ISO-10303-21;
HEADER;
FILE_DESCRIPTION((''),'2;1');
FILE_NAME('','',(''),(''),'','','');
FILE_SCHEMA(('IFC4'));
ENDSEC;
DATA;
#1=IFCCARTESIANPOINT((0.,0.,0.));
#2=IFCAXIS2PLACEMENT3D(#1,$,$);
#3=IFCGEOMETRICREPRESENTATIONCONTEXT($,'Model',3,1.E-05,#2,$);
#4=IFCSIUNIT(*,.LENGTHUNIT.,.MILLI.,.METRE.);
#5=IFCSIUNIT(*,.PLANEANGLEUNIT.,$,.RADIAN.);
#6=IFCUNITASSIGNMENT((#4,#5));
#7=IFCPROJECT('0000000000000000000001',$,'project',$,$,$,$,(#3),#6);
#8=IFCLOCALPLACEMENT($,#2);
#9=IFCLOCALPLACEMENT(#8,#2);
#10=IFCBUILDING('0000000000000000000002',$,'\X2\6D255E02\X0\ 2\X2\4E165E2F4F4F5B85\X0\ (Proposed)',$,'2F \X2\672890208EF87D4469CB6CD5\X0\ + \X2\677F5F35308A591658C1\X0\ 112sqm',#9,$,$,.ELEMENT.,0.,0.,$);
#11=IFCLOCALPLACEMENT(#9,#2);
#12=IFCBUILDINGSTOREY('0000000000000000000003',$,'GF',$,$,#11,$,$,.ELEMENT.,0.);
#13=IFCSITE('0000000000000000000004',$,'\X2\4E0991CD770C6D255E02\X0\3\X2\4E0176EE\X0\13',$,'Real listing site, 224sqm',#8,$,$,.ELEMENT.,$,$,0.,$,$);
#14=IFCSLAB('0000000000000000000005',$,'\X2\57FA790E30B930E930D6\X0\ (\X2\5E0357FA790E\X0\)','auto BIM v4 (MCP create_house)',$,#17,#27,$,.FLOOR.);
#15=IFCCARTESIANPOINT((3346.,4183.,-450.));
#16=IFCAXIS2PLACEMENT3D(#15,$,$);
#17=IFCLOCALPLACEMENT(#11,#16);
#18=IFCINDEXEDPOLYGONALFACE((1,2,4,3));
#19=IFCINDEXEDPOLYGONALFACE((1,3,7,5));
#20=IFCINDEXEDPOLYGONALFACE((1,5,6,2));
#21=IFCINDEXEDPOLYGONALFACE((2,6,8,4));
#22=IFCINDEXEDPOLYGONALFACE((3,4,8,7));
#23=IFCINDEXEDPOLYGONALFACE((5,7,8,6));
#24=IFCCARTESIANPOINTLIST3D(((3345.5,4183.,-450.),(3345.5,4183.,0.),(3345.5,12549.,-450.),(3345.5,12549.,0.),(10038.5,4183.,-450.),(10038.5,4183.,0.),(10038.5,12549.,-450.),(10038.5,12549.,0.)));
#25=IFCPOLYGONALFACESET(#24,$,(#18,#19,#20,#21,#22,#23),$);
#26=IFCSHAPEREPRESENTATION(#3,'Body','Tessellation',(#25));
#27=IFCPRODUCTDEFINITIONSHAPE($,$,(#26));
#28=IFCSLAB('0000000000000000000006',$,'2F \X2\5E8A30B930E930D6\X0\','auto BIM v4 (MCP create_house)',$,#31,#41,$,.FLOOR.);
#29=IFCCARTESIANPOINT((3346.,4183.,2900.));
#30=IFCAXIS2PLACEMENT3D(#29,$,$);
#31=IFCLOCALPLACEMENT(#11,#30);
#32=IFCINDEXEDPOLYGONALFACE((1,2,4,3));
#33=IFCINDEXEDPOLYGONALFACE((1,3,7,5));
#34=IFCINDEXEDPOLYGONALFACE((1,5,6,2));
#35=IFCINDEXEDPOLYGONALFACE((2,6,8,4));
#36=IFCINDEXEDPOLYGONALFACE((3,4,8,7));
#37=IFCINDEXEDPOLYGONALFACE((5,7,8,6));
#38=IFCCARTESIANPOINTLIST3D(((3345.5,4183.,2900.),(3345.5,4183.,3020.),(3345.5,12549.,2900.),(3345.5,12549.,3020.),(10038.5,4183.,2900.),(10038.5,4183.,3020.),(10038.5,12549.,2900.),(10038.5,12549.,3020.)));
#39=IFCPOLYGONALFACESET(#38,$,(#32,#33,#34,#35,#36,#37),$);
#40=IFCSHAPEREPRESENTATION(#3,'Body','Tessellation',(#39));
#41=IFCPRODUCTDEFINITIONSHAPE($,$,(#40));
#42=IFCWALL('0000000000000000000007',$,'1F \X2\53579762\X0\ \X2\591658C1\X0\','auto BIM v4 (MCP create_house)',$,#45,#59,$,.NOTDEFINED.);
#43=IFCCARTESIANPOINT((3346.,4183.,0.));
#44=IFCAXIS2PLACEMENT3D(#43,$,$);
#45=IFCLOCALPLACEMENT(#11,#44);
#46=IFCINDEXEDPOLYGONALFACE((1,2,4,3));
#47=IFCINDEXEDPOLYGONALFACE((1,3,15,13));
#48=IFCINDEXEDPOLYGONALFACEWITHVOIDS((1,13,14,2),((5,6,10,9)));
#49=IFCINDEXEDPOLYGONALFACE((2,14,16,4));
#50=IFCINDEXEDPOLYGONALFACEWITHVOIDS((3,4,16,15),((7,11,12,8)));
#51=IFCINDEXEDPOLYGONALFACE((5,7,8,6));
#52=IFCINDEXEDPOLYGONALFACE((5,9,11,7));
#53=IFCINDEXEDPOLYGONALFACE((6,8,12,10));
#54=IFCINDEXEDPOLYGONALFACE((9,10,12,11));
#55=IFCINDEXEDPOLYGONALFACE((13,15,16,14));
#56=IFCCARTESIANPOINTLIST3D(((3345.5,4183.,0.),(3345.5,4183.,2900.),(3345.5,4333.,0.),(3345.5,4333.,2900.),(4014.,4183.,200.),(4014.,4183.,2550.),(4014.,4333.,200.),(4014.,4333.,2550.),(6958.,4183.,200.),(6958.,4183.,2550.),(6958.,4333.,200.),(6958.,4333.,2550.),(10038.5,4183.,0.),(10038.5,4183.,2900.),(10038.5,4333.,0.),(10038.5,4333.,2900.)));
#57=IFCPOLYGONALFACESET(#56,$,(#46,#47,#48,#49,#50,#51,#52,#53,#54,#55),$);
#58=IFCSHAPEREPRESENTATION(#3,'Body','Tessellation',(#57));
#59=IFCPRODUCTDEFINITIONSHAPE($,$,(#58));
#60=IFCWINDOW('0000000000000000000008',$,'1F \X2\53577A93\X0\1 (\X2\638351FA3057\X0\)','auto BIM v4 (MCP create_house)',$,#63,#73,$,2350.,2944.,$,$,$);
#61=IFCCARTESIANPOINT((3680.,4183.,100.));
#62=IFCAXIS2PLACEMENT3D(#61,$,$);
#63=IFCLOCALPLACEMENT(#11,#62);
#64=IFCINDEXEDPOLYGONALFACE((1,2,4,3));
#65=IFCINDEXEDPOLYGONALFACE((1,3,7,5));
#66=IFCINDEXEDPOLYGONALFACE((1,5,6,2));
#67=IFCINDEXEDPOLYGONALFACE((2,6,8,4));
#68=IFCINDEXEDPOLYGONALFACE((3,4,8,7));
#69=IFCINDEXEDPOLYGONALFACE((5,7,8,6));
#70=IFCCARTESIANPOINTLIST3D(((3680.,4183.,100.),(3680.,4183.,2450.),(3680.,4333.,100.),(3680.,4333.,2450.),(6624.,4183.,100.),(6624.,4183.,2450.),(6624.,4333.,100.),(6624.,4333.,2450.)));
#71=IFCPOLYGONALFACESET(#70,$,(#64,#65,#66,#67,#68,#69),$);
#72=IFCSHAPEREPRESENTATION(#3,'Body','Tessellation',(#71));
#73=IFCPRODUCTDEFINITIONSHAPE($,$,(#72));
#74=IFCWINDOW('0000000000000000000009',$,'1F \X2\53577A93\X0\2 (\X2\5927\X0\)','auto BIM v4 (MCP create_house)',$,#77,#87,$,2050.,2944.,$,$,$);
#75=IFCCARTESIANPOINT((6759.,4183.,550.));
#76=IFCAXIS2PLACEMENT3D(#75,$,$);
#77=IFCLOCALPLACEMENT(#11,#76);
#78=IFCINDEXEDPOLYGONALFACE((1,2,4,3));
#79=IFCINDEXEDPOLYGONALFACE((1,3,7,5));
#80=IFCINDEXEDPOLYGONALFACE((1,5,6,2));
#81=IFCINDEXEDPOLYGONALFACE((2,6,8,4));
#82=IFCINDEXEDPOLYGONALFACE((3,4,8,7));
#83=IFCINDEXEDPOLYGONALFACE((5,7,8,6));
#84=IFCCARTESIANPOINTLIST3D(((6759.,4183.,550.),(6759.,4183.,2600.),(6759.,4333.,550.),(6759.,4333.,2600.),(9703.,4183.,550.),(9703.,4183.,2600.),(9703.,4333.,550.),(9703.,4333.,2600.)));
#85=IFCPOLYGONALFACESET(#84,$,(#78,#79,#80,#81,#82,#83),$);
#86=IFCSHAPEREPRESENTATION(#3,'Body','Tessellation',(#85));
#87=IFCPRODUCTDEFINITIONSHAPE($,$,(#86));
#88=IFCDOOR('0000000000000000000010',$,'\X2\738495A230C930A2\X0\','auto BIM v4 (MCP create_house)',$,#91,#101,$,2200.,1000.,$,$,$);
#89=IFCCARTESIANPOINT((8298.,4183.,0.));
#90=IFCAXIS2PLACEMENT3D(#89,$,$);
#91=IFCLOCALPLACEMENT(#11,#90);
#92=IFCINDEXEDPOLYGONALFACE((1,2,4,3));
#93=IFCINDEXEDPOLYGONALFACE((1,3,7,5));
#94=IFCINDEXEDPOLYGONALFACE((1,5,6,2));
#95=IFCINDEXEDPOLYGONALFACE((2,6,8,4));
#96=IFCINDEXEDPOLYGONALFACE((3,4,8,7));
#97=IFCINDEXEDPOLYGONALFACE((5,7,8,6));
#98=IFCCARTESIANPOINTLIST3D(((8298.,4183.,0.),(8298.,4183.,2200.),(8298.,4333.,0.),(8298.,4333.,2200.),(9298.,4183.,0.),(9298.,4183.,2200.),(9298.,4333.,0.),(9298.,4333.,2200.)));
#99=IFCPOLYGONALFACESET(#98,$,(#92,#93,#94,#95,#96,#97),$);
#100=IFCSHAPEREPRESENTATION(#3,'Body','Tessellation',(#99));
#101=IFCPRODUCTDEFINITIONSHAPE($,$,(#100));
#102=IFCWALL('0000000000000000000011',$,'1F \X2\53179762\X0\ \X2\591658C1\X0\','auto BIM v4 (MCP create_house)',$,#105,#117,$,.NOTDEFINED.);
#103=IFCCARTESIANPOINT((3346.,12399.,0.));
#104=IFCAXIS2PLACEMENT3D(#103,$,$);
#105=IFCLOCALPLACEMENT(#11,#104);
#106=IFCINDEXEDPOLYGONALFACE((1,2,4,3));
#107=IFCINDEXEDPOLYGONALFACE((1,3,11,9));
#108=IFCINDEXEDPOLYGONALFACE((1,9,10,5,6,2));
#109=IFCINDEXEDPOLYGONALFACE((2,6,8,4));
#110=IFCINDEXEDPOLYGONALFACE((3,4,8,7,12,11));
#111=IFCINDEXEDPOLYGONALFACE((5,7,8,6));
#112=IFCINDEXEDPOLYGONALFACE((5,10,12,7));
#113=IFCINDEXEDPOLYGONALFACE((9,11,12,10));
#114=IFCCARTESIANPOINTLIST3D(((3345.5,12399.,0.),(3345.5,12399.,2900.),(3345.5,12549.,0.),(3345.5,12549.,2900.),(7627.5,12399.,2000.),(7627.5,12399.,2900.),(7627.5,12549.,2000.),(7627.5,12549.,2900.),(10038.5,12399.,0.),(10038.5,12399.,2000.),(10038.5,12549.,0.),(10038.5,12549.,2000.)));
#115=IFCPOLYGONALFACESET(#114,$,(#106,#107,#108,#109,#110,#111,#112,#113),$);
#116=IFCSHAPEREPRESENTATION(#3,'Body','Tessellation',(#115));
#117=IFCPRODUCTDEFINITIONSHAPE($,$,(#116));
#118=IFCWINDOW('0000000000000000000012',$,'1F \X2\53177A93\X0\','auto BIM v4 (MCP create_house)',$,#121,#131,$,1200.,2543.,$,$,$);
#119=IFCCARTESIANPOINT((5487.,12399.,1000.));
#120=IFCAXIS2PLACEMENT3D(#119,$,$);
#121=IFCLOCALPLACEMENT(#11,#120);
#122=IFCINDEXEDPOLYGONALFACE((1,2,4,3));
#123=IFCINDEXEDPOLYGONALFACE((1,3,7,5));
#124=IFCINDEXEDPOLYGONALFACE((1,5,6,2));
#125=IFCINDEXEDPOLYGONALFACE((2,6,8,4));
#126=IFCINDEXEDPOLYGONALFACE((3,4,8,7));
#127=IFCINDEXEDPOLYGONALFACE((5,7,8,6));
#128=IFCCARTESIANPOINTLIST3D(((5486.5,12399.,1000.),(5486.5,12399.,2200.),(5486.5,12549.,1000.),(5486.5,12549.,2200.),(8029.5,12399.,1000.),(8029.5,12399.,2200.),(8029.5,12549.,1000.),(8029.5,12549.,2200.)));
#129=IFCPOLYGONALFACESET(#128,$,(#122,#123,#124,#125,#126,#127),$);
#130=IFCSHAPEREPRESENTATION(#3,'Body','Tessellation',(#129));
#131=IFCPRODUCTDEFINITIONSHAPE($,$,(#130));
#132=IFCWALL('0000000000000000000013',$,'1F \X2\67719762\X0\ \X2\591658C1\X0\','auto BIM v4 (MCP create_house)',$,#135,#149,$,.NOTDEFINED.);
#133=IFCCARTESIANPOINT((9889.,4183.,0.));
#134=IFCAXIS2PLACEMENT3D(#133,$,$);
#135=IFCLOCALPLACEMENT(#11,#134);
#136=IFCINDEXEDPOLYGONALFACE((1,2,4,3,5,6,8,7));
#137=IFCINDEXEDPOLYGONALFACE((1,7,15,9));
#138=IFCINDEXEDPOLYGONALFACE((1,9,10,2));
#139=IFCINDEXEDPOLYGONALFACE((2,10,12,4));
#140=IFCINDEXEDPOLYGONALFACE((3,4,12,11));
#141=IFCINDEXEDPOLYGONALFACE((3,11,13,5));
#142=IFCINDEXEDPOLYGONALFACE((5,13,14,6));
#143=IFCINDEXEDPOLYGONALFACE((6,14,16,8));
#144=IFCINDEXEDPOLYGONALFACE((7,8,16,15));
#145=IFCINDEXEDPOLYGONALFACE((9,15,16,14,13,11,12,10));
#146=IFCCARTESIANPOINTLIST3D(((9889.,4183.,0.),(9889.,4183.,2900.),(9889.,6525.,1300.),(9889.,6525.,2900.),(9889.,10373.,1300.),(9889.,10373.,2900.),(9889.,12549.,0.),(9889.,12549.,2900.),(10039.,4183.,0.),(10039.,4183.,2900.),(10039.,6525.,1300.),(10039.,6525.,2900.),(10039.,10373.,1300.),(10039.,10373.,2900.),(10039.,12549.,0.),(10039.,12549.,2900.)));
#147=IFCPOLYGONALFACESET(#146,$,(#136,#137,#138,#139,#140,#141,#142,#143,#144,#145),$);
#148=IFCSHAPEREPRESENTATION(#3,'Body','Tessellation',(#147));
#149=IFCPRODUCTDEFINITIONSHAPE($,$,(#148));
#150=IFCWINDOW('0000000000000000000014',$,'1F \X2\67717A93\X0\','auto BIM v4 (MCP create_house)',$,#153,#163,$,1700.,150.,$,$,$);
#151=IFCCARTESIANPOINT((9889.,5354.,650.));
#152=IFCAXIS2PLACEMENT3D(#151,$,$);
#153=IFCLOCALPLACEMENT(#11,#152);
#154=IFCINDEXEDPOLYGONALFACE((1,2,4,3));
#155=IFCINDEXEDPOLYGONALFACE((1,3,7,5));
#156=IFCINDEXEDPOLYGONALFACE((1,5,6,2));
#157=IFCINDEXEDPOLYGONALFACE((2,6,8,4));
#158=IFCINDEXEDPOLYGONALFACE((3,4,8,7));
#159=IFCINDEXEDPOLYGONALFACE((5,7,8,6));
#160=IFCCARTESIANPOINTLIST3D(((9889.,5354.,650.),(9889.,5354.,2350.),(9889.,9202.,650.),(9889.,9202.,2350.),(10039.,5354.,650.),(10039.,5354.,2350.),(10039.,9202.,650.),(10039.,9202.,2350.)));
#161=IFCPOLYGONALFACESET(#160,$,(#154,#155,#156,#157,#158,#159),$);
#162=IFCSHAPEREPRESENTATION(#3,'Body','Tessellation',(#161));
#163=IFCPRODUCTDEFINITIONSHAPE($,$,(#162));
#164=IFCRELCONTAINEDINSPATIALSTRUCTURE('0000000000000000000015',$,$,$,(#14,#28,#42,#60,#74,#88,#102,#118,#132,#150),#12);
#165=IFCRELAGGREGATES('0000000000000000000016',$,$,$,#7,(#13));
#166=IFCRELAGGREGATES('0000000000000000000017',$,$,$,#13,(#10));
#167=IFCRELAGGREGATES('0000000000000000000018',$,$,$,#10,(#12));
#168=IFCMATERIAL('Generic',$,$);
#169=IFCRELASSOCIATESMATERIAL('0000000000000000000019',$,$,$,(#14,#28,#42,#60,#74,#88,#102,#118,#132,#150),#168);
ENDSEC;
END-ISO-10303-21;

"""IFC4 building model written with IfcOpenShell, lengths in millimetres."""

from ifc_helpers import new_model, si_unit, frame, frame_2d, origin, place, context, project, spatial, rectangle, extrude, material, element, fill, save


model = new_model("IFC4")

# Units and contexts
model_context = context("Model", 3, precision=1e-05, world=origin())
ifc_project = project(units=[si_unit("LENGTHUNIT", "METRE", prefix="MILLI"), si_unit("PLANEANGLEUNIT", "RADIAN")], contexts=[model_context])

# Site, building, storey
site_placement = place(None, origin())
site = spatial("IfcSite", under=ifc_project, at=site_placement, Name="三重県津市3丁目13", ObjectType="Real listing site, 224sqm", CompositionType="ELEMENT", RefElevation=0.0)
building_placement = place(site_placement, origin())
building = spatial("IfcBuilding", under=site, at=building_placement, Name="津市 2世帯住宅 (Proposed)", ObjectType="2F 木造軸組構法 + 板張り外壁 112sqm", CompositionType="ELEMENT", ElevationOfRefHeight=0.0, ElevationOfTerrain=0.0)
storey_placement = place(building_placement, origin())
storey = spatial("IfcBuildingStorey", under=building, at=storey_placement, Name="GF", CompositionType="ELEMENT", Elevation=0.0)

# Slabs
ifc_material = material(Name="Generic")
slab_1_placement = place(storey_placement, frame((3346.0, 4183.0, -450.0)))
element("IfcSlab", 1, at=slab_1_placement, inside=storey, material=ifc_material, Name="基礎スラブ (布基礎)", Description="auto BIM v4 (MCP create_house)", PredefinedType="FLOOR", context=model_context, shape_type="SweptSolid", body=[
    extrude(rectangle(XDim=6693.0, YDim=8366.0, at=frame_2d((3346.0, 4183.0))), frame((3346.0, 4183.0, -450.0)), (0.0, 0.0, 1.0), 450.0),
])
slab_2_placement = place(storey_placement, frame((3346.0, 4183.0, 2900.0)))
element("IfcSlab", 2, at=slab_2_placement, inside=storey, material=ifc_material, Name="2F 床スラブ", Description="auto BIM v4 (MCP create_house)", PredefinedType="FLOOR", context=model_context, shape_type="SweptSolid", body=[
    extrude(rectangle(XDim=6693.0, YDim=8366.0, at=frame_2d((3346.0, 4183.0))), frame((3346.0, 4183.0, 2900.0)), (0.0, 0.0, 1.0), 120.0),
])

# Wall, openings, windows, door
wall_1_placement = place(storey_placement, frame((3346.0, 4183.0, 0.0)))
wall_1 = element("IfcWall", 3, at=wall_1_placement, inside=storey, material=ifc_material, Name="1F 南面 外壁", Description="auto BIM v4 (MCP create_house)", PredefinedType="NOTDEFINED", context=model_context, shape_type="SweptSolid", body=[
    extrude(rectangle(XDim=6693.0, YDim=150.0, at=frame_2d((3346.0, 75.0))), frame((3346.0, 4183.0, 0.0)), (0.0, 0.0, 1.0), 2900.0),
])
opening_1_placement = place(storey_placement, frame((3680.0, 4183.0, 100.0)))
opening_1 = element("IfcOpeningElement", 4, at=opening_1_placement, cuts=wall_1, PredefinedType="NOTDEFINED", context=model_context, shape_type="SweptSolid", body=[
    extrude(rectangle(XDim=2944.0, YDim=150.0, at=frame_2d((1472.0, 75.0))), frame((3680.0, 4183.0, 100.0)), (0.0, 0.0, 1.0), 2350.0),
])
opening_2_placement = place(storey_placement, frame((6759.0, 4183.0, 550.0)))
opening_2 = element("IfcOpeningElement", 5, at=opening_2_placement, cuts=wall_1, PredefinedType="NOTDEFINED", context=model_context, shape_type="SweptSolid", body=[
    extrude(rectangle(XDim=2944.0, YDim=150.0, at=frame_2d((1472.0, 75.0))), frame((6759.0, 4183.0, 550.0)), (0.0, 0.0, 1.0), 2050.0),
])
opening_3_placement = place(storey_placement, frame((8298.0, 4183.0, 0.0)))
opening_3 = element("IfcOpeningElement", 6, at=opening_3_placement, cuts=wall_1, PredefinedType="NOTDEFINED", context=model_context, shape_type="SweptSolid", body=[
    extrude(rectangle(XDim=1000.0, YDim=150.0, at=frame_2d((500.0, 75.0))), frame((8298.0, 4183.0, 0.0)), (0.0, 0.0, 1.0), 2200.0),
])
window_1_placement = place(storey_placement, frame((3680.0, 4183.0, 100.0)))
window_1 = element("IfcWindow", 7, at=window_1_placement, inside=storey, material=ifc_material, Name="1F 南窓1 (掃出し)", Description="auto BIM v4 (MCP create_house)", OverallHeight=2350.0, OverallWidth=2944.0, context=model_context, shape_type="SweptSolid", body=[
    extrude(rectangle(XDim=2944.0, YDim=150.0, at=frame_2d((1472.0, 75.0))), frame((3680.0, 4183.0, 100.0)), (0.0, 0.0, 1.0), 2350.0),
])
fill(opening_1, window_1)
window_2_placement = place(storey_placement, frame((6759.0, 4183.0, 550.0)))
window_2 = element("IfcWindow", 8, at=window_2_placement, inside=storey, material=ifc_material, Name="1F 南窓2 (大)", Description="auto BIM v4 (MCP create_house)", OverallHeight=2050.0, OverallWidth=2944.0, context=model_context, shape_type="SweptSolid", body=[
    extrude(rectangle(XDim=2944.0, YDim=150.0, at=frame_2d((1472.0, 75.0))), frame((6759.0, 4183.0, 550.0)), (0.0, 0.0, 1.0), 2050.0),
])
fill(opening_2, window_2)
door_1_placement = place(storey_placement, frame((8298.0, 4183.0, 0.0)))
door_1 = element("IfcDoor", 9, at=door_1_placement, inside=storey, material=ifc_material, Name="玄関ドア", Description="auto BIM v4 (MCP create_house)", OverallHeight=2200.0, OverallWidth=1000.0, context=model_context, shape_type="SweptSolid", body=[
    extrude(rectangle(XDim=1000.0, YDim=150.0, at=frame_2d((500.0, 75.0))), frame((8298.0, 4183.0, 0.0)), (0.0, 0.0, 1.0), 2200.0),
])
fill(opening_3, door_1)

# Walls, openings, windows
wall_2_placement = place(storey_placement, frame((3346.0, 12399.0, 0.0)))
wall_2 = element("IfcWall", 10, at=wall_2_placement, inside=storey, material=ifc_material, Name="1F 北面 外壁", Description="auto BIM v4 (MCP create_house)", PredefinedType="NOTDEFINED", context=model_context, shape_type="SweptSolid", body=[
    extrude(rectangle(XDim=6693.0, YDim=150.0, at=frame_2d((3346.0, 75.0))), frame((3346.0, 12399.0, 0.0)), (0.0, 0.0, 1.0), 2900.0),
])
opening_4_placement = place(storey_placement, frame((5487.0, 12399.0, 1000.0)))
opening_4 = element("IfcOpeningElement", 11, at=opening_4_placement, cuts=wall_2, PredefinedType="NOTDEFINED", context=model_context, shape_type="SweptSolid", body=[
    extrude(rectangle(XDim=2543.0, YDim=150.0, at=frame_2d((1271.0, 75.0))), frame((5487.0, 12399.0, 1000.0)), (0.0, 0.0, 1.0), 1200.0),
])
window_3_placement = place(storey_placement, frame((5487.0, 12399.0, 1000.0)))
window_3 = element("IfcWindow", 12, at=window_3_placement, inside=storey, material=ifc_material, Name="1F 北窓", Description="auto BIM v4 (MCP create_house)", OverallHeight=1200.0, OverallWidth=2543.0, context=model_context, shape_type="SweptSolid", body=[
    extrude(rectangle(XDim=2543.0, YDim=150.0, at=frame_2d((1271.0, 75.0))), frame((5487.0, 12399.0, 1000.0)), (0.0, 0.0, 1.0), 1200.0),
])
fill(opening_4, window_3)
wall_3_placement = place(storey_placement, frame((9889.0, 4183.0, 0.0)))
wall_3 = element("IfcWall", 13, at=wall_3_placement, inside=storey, material=ifc_material, Name="1F 東面 外壁", Description="auto BIM v4 (MCP create_house)", PredefinedType="NOTDEFINED", context=model_context, shape_type="SweptSolid", body=[
    extrude(rectangle(XDim=150.0, YDim=8366.0, at=frame_2d((75.0, 4183.0))), frame((9889.0, 4183.0, 0.0)), (0.0, 0.0, 1.0), 2900.0),
])
opening_5_placement = place(storey_placement, frame((9889.0, 5354.0, 650.0)))
opening_5 = element("IfcOpeningElement", 14, at=opening_5_placement, cuts=wall_3, PredefinedType="NOTDEFINED", context=model_context, shape_type="SweptSolid", body=[
    extrude(rectangle(XDim=150.0, YDim=3848.0, at=frame_2d((75.0, 1924.0))), frame((9889.0, 5354.0, 650.0)), (0.0, 0.0, 1.0), 1700.0),
])
window_4_placement = place(storey_placement, frame((9889.0, 5354.0, 650.0)))
window_4 = element("IfcWindow", 15, at=window_4_placement, inside=storey, material=ifc_material, Name="1F 東窓", Description="auto BIM v4 (MCP create_house)", OverallHeight=1700.0, OverallWidth=150.0, context=model_context, shape_type="SweptSolid", body=[
    extrude(rectangle(XDim=150.0, YDim=3848.0, at=frame_2d((75.0, 1924.0))), frame((9889.0, 5354.0, 650.0)), (0.0, 0.0, 1.0), 1700.0),
])
fill(opening_5, window_4)

save(model, "model.ifc")
